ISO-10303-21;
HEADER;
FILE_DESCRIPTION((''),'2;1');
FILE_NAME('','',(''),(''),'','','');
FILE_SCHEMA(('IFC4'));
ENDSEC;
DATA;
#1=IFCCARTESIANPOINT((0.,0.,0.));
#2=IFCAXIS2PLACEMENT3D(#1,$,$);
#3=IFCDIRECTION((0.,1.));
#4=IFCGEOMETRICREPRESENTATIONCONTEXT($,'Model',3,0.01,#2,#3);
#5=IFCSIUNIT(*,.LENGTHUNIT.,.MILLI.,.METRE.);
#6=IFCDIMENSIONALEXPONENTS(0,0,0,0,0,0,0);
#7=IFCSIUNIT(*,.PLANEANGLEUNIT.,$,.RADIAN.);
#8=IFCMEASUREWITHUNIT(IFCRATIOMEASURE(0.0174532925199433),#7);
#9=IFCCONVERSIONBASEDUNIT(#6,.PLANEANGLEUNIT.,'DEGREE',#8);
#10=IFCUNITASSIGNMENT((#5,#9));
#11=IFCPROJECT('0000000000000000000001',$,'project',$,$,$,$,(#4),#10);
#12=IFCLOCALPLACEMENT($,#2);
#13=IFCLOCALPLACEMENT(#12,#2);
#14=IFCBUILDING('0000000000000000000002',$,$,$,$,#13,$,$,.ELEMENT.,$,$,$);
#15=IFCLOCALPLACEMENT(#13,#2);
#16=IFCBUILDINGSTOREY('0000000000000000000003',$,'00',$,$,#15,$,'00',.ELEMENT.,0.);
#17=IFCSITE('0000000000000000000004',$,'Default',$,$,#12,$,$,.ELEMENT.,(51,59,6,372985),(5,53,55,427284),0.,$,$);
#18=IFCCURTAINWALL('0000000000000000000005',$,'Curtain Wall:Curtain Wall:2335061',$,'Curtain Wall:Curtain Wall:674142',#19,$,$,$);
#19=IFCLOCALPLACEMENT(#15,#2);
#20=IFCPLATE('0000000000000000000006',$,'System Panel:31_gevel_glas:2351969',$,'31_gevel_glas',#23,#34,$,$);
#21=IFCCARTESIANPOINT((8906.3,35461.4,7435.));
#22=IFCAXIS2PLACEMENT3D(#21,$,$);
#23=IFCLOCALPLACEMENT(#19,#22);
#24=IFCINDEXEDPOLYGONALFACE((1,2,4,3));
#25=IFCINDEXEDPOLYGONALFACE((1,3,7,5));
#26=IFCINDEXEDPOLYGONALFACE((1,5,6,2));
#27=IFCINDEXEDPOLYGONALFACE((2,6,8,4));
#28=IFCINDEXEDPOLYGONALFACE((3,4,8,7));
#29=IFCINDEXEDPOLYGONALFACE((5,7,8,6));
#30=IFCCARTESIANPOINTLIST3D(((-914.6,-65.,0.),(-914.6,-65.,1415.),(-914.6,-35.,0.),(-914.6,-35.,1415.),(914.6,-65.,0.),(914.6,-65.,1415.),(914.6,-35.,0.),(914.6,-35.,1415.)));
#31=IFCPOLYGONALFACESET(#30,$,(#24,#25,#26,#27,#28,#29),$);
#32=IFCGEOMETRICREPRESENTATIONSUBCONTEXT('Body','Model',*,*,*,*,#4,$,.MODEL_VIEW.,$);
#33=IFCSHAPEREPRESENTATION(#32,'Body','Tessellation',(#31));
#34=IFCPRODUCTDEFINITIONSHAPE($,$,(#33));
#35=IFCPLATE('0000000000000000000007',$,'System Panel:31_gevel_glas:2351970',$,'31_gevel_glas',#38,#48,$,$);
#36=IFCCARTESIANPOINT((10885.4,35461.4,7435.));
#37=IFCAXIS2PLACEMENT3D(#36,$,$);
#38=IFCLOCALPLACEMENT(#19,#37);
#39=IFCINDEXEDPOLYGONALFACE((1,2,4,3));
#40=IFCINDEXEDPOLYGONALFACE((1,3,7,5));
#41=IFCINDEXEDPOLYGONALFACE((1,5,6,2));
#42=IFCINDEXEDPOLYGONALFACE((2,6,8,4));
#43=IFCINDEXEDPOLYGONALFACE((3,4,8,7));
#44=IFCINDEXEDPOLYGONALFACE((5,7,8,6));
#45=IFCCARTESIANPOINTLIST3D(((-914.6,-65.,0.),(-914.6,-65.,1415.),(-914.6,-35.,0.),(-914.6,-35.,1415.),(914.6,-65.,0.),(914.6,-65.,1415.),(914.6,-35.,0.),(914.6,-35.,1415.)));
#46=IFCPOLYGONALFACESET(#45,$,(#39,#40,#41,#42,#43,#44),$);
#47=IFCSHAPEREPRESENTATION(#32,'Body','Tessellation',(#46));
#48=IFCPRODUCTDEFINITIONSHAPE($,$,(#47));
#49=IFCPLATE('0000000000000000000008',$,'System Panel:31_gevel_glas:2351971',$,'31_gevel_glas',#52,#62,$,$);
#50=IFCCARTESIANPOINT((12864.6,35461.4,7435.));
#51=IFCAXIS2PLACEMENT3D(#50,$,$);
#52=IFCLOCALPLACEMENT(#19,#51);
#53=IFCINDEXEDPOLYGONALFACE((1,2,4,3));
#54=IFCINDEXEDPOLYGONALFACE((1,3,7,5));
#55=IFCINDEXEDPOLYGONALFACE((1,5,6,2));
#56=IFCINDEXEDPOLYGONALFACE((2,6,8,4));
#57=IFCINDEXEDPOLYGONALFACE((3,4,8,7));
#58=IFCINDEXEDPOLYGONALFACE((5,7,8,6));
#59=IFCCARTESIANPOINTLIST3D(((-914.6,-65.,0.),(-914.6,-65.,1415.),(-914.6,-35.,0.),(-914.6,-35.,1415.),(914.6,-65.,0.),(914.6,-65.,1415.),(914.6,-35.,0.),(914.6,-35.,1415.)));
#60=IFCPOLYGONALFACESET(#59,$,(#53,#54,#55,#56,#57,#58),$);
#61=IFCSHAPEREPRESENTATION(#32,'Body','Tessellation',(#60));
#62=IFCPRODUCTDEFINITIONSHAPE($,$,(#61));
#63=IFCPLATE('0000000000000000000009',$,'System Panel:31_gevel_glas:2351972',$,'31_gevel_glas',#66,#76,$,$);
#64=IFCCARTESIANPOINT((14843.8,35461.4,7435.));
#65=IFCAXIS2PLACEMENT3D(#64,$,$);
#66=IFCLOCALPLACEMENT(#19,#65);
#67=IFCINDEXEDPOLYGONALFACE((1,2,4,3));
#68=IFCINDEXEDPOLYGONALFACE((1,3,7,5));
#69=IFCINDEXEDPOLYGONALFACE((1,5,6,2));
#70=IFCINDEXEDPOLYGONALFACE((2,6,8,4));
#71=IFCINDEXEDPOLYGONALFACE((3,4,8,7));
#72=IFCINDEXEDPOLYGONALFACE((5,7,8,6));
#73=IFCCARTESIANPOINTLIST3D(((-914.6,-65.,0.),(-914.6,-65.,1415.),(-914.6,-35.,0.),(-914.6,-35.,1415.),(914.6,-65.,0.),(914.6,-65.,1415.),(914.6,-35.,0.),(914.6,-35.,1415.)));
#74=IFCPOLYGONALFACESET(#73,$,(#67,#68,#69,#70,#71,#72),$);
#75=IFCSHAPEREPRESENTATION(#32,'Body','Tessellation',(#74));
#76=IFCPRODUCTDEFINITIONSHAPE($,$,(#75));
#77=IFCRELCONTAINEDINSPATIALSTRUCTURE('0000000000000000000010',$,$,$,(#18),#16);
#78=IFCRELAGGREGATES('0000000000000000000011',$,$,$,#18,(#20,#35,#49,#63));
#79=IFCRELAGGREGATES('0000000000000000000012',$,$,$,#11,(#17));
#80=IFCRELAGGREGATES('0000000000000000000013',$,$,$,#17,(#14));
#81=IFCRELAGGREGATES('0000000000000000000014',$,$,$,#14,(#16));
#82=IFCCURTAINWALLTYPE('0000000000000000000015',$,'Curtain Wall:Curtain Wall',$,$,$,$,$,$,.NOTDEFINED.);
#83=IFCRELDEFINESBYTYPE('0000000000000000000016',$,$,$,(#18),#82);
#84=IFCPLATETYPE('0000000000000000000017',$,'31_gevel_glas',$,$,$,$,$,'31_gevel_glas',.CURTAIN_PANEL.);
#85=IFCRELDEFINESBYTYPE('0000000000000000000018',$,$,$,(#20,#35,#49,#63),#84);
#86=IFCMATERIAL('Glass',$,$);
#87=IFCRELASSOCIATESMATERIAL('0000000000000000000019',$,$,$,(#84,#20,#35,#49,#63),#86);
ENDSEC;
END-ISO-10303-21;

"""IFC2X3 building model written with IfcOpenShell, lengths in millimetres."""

from ifc_helpers import new_model, entity, si_unit, converted_unit, direction, frame, origin, origin_2d_with_axis, place, context, subcontext, project, spatial, rectangle, extrude, source, transform, mapped, material, type_object, type_shapes, element, aggregate, save


model = new_model("IFC2X3")

# Units and contexts
model_context = context("Model", 3, precision=0.01, world=origin(), true_north=direction((0.0, 1.0)))
body_context = subcontext(model_context, "Body", "Model", "MODEL_VIEW")
ifc_project = project(units=[si_unit("LENGTHUNIT", "METRE", prefix="MILLI"), converted_unit("PLANEANGLEUNIT", "DEGREE", entity("IfcRatioMeasure", 0.0174532925199433), si_unit("PLANEANGLEUNIT", "RADIAN"), dimensions=[0, 0, 0, 0, 0, 0, 0])], contexts=[model_context])

# Site, building, storey
site_placement = place(None, origin())
site = spatial("IfcSite", under=ifc_project, at=site_placement, Name="Default", CompositionType="ELEMENT", RefLatitude=(51, 59, 6, 372985), RefLongitude=(5, 53, 55, 427284), RefElevation=0.0)
building_placement = place(site_placement, origin())
building = spatial("IfcBuilding", under=site, at=building_placement, CompositionType="ELEMENT")
storey_placement = place(building_placement, origin())
storey = spatial("IfcBuildingStorey", under=building, at=storey_placement, Name="00", LongName="00", CompositionType="ELEMENT", Elevation=0.0)

# Curtain wall, plates
curtain_wall_type = type_object("IfcCurtainWallType", Name="Curtain Wall:Curtain Wall", PredefinedType="NOTDEFINED")
curtain_wall_placement = place(storey_placement, origin())
curtain_wall = element("IfcCurtainWall", 1, at=curtain_wall_placement, inside=storey, type_object=curtain_wall_type, Name="Curtain Wall:Curtain Wall:2335061", ObjectType="Curtain Wall:Curtain Wall:674142")
ifc_material_1 = material(Name="Glass")
plate_type_1 = type_object("IfcPlateType", Name="31_gevel_glas", ElementType="31_gevel_glas", PredefinedType="CURTAIN_PANEL", material=ifc_material_1)
shared_shape_1 = source(origin(), body_context, "Body", "SweptSolid", [
    extrude(rectangle(XDim=30.0, YDim=1829.2, at=origin_2d_with_axis()), frame((0.0, -50.0, 0.0), z_axis=(0.0, 0.0, 1.0), x_axis=(0.0, 1.0, 0.0)), (0.0, 0.0, 1.0), 1415.0),
])
type_shapes(plate_type_1, [shared_shape_1])
plate_1_placement = place(curtain_wall_placement, frame((8906.3, 35461.4, 7435.0)))
plate_1 = element("IfcPlate", 2, at=plate_1_placement, type_object=plate_type_1, material=ifc_material_1, Name="System Panel:31_gevel_glas:2351969", ObjectType="31_gevel_glas", context=body_context, shape_type="MappedRepresentation", body=[
    mapped(shared_shape_1, transform((0.0, 0.0, 0.0), scale=1.0)),
])
plate_2_placement = place(curtain_wall_placement, frame((10885.4, 35461.4, 7435.0)))
plate_2 = element("IfcPlate", 3, at=plate_2_placement, type_object=plate_type_1, material=ifc_material_1, Name="System Panel:31_gevel_glas:2351970", ObjectType="31_gevel_glas", context=body_context, shape_type="MappedRepresentation", body=[
    mapped(shared_shape_1, transform((0.0, 0.0, 0.0), scale=1.0)),
])
plate_3_placement = place(curtain_wall_placement, frame((12864.6, 35461.4, 7435.0)))
plate_3 = element("IfcPlate", 4, at=plate_3_placement, type_object=plate_type_1, material=ifc_material_1, Name="System Panel:31_gevel_glas:2351971", ObjectType="31_gevel_glas", context=body_context, shape_type="MappedRepresentation", body=[
    mapped(shared_shape_1, transform((0.0, 0.0, 0.0), scale=1.0)),
])
plate_4_placement = place(curtain_wall_placement, frame((14843.8, 35461.4, 7435.0)))
plate_4 = element("IfcPlate", 5, at=plate_4_placement, type_object=plate_type_1, material=ifc_material_1, Name="System Panel:31_gevel_glas:2351972", ObjectType="31_gevel_glas", context=body_context, shape_type="MappedRepresentation", body=[
    mapped(shared_shape_1, transform((0.0, 0.0, 0.0), scale=1.0)),
])
aggregate(curtain_wall, [plate_1, plate_2, plate_3, plate_4])

save(model, "model.ifc")
